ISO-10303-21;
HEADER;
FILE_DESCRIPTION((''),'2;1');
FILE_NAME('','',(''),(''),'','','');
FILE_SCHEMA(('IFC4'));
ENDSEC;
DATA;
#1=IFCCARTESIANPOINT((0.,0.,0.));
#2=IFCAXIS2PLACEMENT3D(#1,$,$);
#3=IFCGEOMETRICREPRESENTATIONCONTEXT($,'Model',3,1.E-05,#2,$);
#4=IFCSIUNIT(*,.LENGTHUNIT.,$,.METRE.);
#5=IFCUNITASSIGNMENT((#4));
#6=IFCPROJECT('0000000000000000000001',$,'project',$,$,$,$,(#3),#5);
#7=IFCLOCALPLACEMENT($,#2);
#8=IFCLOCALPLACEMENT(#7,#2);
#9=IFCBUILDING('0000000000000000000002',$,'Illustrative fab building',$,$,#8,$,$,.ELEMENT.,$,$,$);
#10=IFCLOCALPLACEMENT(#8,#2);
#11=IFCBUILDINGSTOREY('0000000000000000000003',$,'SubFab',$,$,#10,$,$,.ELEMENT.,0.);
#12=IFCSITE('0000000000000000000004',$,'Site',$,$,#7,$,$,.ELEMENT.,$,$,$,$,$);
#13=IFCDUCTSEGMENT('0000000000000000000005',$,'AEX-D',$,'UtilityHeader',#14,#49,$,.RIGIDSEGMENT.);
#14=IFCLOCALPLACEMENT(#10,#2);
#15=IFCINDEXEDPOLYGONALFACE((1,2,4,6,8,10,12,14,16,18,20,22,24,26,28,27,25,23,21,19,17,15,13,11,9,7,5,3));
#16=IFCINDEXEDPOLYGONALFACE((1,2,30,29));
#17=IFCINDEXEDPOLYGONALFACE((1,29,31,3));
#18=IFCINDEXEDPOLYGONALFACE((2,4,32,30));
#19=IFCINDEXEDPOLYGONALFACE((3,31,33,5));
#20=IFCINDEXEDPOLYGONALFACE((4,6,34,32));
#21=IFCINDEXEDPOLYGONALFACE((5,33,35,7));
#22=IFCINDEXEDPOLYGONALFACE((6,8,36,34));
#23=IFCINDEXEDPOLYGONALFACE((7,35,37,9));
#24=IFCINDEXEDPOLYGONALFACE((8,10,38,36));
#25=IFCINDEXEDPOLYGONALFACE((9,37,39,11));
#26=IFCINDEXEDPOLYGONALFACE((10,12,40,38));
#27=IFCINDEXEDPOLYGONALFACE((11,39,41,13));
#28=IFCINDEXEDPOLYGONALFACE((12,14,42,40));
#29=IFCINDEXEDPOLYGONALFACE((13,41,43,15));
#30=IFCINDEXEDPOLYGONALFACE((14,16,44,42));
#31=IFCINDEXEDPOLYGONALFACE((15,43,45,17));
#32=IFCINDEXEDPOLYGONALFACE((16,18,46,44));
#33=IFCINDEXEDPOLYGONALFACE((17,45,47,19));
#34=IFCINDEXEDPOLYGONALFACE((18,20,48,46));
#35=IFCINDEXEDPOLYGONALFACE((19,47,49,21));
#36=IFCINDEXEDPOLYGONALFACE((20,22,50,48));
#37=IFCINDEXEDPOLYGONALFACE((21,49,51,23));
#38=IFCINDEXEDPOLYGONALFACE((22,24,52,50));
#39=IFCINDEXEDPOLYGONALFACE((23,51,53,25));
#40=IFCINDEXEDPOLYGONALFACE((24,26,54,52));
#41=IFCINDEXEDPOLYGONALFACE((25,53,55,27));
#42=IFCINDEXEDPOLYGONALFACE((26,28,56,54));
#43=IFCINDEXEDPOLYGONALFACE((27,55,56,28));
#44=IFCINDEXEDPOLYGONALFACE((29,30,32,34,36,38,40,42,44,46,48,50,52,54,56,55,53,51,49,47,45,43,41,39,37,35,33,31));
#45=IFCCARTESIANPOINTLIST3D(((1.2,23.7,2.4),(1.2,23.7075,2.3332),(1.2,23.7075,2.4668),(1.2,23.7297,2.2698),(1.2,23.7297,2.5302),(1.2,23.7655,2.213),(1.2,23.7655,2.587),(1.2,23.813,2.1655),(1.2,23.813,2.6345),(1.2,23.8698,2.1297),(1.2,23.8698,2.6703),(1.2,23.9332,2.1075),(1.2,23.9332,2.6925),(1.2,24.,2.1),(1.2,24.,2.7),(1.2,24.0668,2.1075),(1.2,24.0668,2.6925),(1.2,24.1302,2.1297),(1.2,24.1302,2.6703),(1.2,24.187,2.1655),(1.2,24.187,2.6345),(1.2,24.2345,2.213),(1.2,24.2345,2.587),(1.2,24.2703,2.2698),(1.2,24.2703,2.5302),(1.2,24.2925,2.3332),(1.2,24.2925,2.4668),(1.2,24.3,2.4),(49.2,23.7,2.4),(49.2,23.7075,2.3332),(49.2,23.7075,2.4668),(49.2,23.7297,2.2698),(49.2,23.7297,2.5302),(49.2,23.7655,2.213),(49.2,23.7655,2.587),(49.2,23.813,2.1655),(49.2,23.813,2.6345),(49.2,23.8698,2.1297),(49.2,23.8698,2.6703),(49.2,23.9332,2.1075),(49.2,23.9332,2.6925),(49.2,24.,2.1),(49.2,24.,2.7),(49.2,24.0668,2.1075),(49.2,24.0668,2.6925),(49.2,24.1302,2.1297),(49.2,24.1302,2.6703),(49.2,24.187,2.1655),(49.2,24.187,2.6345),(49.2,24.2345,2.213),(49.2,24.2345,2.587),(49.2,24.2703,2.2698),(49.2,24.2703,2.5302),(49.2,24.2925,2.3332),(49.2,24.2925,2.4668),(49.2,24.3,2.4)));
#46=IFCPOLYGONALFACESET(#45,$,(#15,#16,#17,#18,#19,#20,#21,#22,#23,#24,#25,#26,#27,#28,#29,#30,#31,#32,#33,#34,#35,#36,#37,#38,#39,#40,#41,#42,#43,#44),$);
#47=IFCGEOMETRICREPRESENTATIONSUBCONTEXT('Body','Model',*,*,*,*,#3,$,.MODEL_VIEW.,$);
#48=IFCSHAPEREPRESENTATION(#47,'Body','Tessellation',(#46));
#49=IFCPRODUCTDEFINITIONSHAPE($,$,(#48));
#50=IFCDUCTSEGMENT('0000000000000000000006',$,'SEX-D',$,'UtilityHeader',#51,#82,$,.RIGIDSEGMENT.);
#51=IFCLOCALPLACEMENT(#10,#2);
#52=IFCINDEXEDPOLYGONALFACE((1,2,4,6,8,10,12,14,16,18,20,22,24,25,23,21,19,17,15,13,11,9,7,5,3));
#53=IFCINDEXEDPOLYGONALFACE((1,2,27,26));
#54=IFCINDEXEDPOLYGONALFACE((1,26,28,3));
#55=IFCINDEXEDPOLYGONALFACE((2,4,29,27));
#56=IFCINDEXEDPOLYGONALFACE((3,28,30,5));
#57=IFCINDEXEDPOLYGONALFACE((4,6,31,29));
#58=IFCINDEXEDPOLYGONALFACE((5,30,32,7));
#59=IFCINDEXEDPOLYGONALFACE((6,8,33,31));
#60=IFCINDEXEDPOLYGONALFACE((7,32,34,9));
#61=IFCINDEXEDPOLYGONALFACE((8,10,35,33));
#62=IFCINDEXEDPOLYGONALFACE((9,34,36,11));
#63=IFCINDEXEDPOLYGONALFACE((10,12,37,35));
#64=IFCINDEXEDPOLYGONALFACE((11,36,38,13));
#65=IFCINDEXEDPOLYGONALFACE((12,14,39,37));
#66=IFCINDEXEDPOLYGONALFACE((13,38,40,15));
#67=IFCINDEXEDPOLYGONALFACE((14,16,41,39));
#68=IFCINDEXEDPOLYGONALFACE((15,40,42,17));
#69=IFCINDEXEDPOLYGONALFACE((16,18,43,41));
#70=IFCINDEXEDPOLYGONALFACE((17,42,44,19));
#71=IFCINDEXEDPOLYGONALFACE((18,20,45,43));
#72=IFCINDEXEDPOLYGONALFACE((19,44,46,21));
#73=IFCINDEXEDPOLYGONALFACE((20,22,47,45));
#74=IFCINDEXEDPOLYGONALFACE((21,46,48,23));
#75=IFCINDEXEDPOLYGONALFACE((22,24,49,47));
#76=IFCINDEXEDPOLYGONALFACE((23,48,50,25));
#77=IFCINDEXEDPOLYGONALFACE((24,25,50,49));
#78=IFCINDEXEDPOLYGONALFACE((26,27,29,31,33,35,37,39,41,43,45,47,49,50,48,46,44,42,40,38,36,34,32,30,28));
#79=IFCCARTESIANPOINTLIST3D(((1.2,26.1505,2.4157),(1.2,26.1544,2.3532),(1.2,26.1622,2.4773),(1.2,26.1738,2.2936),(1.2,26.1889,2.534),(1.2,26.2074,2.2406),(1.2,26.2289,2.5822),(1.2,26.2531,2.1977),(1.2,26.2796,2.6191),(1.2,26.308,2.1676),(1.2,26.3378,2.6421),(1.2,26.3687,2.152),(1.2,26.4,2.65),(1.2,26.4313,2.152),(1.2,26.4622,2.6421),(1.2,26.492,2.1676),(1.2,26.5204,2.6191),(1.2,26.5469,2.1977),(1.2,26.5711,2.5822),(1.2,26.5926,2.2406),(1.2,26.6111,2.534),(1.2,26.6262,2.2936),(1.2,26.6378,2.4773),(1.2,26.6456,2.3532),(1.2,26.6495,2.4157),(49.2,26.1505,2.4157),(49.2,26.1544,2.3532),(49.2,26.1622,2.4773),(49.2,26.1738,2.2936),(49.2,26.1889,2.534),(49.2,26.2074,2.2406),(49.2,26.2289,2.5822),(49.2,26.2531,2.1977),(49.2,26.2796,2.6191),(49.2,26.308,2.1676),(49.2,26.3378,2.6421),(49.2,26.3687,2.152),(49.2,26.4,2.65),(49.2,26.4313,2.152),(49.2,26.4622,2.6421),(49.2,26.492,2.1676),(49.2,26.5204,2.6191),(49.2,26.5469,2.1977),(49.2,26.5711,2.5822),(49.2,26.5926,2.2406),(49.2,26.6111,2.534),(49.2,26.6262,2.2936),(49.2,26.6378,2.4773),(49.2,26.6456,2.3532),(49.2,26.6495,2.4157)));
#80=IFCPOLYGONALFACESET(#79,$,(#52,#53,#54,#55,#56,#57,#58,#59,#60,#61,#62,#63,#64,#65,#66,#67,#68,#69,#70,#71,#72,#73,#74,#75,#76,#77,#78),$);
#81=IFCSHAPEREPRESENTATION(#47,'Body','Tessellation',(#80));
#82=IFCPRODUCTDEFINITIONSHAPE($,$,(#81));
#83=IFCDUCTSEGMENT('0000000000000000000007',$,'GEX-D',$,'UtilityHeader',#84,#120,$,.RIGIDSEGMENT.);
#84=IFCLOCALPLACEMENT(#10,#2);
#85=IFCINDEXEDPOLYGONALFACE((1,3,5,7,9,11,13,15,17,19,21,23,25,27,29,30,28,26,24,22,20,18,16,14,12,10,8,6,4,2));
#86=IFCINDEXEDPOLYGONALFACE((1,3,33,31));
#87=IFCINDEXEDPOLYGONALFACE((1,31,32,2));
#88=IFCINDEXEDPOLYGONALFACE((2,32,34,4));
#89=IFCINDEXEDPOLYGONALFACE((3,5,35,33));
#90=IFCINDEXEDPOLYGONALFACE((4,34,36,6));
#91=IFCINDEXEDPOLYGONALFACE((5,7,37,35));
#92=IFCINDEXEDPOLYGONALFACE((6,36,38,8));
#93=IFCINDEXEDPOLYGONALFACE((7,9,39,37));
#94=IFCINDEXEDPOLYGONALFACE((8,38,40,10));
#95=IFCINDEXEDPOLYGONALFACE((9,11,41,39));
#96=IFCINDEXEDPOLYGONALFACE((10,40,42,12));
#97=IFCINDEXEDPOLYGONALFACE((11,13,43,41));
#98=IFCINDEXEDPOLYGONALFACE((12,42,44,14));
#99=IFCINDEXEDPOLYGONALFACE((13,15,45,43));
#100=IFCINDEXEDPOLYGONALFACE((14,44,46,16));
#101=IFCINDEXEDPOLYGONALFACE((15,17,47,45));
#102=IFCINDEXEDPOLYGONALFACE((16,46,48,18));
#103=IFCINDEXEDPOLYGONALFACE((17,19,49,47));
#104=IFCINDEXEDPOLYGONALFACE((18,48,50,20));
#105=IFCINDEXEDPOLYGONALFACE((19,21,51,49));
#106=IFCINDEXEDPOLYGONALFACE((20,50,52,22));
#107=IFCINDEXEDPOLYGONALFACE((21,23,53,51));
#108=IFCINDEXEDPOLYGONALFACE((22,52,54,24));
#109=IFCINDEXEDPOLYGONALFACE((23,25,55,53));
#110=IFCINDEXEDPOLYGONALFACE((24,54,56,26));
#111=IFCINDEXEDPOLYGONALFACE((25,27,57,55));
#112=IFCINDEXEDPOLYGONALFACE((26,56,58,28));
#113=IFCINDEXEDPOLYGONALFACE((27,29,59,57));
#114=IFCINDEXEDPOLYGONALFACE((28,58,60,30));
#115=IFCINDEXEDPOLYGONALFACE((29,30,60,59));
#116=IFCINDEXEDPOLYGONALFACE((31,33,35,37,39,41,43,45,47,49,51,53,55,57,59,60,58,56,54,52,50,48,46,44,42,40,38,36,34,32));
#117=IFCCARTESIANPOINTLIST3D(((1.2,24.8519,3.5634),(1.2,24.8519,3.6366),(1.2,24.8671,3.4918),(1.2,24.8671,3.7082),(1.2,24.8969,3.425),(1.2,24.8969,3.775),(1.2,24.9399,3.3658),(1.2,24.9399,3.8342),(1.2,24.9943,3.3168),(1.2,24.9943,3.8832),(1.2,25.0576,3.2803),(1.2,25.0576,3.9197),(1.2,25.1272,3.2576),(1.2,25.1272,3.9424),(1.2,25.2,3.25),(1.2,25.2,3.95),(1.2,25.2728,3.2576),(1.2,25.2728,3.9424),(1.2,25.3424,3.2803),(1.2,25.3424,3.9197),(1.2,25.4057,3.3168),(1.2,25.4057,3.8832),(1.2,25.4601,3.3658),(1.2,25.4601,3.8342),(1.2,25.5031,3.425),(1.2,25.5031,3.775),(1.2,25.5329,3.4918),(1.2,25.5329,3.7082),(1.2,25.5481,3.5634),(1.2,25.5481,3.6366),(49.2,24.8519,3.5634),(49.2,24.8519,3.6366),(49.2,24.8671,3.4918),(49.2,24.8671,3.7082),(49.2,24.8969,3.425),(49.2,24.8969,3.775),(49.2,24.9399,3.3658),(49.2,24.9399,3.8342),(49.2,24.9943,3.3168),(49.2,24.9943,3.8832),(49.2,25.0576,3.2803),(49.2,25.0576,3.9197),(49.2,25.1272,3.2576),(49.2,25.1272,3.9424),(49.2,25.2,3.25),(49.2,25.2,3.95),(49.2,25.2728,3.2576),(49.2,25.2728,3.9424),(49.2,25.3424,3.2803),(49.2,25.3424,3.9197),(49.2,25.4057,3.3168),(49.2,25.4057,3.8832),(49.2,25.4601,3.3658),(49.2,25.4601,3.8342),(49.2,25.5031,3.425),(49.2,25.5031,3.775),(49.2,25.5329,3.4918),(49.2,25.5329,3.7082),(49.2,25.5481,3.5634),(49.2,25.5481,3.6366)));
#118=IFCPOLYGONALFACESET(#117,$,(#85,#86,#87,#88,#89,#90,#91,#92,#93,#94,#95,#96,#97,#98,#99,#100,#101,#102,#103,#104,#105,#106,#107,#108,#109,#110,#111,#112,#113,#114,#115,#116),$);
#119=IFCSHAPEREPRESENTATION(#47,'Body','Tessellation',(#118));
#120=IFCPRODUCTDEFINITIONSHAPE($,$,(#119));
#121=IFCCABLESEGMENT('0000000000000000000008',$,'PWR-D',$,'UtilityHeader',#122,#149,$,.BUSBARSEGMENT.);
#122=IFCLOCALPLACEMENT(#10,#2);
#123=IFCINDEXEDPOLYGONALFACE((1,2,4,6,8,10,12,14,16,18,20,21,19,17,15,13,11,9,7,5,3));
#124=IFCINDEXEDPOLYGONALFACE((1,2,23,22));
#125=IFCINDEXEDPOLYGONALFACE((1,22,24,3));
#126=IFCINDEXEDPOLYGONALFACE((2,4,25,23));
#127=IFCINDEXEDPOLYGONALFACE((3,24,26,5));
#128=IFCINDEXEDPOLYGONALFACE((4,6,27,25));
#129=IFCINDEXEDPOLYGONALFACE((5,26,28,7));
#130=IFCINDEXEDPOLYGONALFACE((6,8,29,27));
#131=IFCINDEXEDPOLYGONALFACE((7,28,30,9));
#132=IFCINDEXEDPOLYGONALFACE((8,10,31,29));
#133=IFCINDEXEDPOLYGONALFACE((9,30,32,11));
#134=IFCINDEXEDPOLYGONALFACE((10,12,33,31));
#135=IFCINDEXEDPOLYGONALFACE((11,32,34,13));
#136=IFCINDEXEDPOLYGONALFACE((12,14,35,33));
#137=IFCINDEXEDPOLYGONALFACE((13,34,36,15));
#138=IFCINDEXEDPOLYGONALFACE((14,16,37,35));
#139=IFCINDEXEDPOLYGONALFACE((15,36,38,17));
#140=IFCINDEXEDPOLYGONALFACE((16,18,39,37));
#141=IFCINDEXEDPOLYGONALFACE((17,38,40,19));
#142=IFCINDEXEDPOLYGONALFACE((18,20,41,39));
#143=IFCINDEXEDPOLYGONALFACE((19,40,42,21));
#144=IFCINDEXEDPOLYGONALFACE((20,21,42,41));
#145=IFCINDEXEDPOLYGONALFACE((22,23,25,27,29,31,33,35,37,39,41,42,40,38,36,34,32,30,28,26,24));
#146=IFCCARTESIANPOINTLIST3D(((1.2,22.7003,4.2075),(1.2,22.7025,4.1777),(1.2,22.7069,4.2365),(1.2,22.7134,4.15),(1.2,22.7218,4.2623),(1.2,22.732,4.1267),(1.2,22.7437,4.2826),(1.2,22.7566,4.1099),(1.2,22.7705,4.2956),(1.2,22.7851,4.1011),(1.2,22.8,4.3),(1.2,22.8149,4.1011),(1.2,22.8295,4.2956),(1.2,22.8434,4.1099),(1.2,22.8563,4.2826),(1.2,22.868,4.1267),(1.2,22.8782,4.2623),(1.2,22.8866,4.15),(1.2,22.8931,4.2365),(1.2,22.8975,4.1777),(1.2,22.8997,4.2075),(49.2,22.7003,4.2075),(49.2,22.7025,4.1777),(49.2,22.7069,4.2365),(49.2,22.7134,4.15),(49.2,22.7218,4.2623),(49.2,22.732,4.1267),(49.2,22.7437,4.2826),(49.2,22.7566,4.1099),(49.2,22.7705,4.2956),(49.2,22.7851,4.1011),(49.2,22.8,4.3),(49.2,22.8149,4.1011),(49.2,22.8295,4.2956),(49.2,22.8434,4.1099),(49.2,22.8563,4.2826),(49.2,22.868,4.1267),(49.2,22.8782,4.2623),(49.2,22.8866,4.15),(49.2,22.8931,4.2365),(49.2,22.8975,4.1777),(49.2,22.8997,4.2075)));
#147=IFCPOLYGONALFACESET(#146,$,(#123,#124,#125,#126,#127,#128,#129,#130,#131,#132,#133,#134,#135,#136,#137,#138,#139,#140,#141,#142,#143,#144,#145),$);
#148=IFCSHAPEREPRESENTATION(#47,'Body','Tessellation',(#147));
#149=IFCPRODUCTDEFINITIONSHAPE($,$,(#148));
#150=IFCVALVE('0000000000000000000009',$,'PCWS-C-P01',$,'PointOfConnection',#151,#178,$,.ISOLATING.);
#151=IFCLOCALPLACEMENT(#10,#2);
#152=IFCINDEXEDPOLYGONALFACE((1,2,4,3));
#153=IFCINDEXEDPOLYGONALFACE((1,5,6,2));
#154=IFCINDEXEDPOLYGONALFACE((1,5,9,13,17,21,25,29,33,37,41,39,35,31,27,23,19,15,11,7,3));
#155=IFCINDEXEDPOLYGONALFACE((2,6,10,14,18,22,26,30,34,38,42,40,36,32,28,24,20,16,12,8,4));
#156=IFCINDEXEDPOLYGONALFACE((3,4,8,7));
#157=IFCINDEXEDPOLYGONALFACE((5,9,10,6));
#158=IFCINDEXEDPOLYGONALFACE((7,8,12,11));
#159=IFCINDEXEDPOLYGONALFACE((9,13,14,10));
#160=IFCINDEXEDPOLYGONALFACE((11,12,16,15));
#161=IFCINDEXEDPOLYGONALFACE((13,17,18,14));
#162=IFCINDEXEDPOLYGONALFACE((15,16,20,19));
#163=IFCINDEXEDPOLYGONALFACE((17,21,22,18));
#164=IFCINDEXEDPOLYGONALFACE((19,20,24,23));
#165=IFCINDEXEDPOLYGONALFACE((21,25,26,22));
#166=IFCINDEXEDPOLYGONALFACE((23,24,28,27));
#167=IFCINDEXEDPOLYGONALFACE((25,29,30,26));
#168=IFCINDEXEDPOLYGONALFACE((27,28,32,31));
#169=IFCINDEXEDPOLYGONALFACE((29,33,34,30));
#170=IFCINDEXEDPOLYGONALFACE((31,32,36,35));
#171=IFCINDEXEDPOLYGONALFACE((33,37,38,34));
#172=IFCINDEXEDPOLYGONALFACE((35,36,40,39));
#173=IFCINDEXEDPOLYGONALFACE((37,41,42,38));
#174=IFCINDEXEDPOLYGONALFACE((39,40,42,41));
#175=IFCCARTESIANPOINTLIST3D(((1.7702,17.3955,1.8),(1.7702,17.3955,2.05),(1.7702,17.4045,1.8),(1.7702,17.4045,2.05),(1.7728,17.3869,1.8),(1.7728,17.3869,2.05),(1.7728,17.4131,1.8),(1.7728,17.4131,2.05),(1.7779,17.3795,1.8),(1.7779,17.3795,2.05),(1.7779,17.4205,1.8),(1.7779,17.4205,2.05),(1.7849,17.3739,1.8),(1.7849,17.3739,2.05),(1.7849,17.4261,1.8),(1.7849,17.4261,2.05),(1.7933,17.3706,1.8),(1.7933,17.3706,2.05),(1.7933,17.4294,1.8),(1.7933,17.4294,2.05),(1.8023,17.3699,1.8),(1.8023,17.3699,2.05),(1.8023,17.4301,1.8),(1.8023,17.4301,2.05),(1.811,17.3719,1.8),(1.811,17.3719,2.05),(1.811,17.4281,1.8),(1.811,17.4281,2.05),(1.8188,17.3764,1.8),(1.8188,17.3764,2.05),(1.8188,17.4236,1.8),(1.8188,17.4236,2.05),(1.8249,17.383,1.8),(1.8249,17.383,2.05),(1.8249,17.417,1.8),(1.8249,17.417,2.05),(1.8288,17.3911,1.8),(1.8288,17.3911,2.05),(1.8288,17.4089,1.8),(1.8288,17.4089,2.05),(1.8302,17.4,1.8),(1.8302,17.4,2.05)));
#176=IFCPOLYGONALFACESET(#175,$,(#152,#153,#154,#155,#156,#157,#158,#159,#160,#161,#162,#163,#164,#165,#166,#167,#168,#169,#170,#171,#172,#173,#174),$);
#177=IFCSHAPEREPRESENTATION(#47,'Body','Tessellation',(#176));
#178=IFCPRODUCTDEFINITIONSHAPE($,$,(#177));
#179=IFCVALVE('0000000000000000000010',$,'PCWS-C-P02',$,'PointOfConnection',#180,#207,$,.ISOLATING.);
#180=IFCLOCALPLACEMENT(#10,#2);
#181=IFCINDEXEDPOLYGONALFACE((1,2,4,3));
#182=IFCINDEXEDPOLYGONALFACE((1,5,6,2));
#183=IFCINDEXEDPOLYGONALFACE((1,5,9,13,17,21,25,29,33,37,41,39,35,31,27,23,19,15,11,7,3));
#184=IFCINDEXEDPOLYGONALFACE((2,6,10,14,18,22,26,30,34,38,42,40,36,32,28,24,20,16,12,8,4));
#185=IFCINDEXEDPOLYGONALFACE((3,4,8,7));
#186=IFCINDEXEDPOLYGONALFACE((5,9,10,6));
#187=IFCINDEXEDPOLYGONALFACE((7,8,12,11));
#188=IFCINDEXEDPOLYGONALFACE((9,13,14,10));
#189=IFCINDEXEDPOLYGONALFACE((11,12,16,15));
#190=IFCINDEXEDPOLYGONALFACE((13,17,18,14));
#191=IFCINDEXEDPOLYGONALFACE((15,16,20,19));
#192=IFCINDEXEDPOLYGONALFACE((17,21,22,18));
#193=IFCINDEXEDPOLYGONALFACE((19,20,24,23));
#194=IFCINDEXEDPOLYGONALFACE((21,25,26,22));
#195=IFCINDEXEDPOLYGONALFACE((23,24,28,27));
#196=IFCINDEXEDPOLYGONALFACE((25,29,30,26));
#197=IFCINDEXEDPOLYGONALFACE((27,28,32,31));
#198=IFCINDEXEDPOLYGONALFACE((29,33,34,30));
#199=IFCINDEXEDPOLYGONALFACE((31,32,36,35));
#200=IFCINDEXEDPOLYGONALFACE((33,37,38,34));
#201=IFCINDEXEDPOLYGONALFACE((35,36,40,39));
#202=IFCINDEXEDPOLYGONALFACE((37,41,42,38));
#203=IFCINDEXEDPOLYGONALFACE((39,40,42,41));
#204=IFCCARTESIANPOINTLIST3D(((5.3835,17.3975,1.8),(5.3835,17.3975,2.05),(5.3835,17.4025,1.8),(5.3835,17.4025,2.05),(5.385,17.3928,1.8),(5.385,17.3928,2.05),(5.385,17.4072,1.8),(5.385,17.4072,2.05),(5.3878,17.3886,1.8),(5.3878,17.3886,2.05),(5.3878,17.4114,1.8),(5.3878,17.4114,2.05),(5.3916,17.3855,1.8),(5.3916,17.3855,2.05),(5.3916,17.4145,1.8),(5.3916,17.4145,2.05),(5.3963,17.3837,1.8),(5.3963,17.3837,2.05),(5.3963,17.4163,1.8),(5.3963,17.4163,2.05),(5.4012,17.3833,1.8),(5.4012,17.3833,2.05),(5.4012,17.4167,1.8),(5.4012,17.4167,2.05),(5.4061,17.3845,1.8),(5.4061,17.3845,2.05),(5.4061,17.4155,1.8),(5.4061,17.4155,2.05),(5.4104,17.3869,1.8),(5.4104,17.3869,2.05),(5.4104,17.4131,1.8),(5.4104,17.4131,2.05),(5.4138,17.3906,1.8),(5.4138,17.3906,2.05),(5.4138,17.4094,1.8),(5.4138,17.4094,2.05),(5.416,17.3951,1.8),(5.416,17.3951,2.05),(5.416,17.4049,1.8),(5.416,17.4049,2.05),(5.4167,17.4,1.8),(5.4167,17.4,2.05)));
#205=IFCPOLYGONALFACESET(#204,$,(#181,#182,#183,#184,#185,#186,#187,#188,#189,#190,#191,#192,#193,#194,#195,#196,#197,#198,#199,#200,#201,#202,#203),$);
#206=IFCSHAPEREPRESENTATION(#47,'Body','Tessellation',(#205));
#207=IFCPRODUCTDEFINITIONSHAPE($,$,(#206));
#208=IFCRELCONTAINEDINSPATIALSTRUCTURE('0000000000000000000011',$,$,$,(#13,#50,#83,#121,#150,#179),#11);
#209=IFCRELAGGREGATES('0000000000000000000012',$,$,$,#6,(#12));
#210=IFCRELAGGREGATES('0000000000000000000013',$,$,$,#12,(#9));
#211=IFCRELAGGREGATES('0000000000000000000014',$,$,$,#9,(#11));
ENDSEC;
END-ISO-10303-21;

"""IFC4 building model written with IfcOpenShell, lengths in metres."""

from ifc_helpers import new_model, entity, si_unit, frame, origin, place, context, subcontext, project, spatial, element, save


model = new_model("IFC4")

# Units and contexts
model_context = context("Model", 3, precision=1e-05, world=origin())
body_context = subcontext(model_context, "Body", "Model", "MODEL_VIEW")
ifc_project = project(units=[si_unit("LENGTHUNIT", "METRE")], contexts=[model_context])

# Site, building, storey
site_placement = place(None, origin())
site = spatial("IfcSite", under=ifc_project, at=site_placement, Name="Site", CompositionType="ELEMENT")
building_placement = place(site_placement, origin())
building = spatial("IfcBuilding", under=site, at=building_placement, Name="Illustrative fab building", CompositionType="ELEMENT")
storey_placement = place(building_placement, origin())
storey = spatial("IfcBuildingStorey", under=building, at=storey_placement, Name="SubFab", CompositionType="ELEMENT", Elevation=0.0)

# Duct segments
duct_segment_1_placement = place(storey_placement, frame((1.2, 24.0, 2.4)))
element("IfcDuctSegment", 1, at=duct_segment_1_placement, inside=storey, Name="AEX-D", ObjectType="UtilityHeader", PredefinedType="RIGIDSEGMENT", context=body_context, shape_type="AdvancedSweptSolid", body=[
    entity("IfcSweptDiskSolid", entity("IfcPolyline", [entity("IfcCartesianPoint", [0.0, 0.0, 0.0]), entity("IfcCartesianPoint", [48.0, 0.0, 0.0])]), 0.3),
])
duct_segment_2_placement = place(storey_placement, frame((1.2, 26.4, 2.4)))
element("IfcDuctSegment", 2, at=duct_segment_2_placement, inside=storey, Name="SEX-D", ObjectType="UtilityHeader", PredefinedType="RIGIDSEGMENT", context=body_context, shape_type="AdvancedSweptSolid", body=[
    entity("IfcSweptDiskSolid", entity("IfcPolyline", [entity("IfcCartesianPoint", [0.0, 0.0, 0.0]), entity("IfcCartesianPoint", [48.0, 0.0, 0.0])]), 0.25),
])
duct_segment_3_placement = place(storey_placement, frame((1.2, 25.2, 3.6)))
element("IfcDuctSegment", 3, at=duct_segment_3_placement, inside=storey, Name="GEX-D", ObjectType="UtilityHeader", PredefinedType="RIGIDSEGMENT", context=body_context, shape_type="AdvancedSweptSolid", body=[
    entity("IfcSweptDiskSolid", entity("IfcPolyline", [entity("IfcCartesianPoint", [0.0, 0.0, 0.0]), entity("IfcCartesianPoint", [48.0, 0.0, 0.0])]), 0.35),
])

# Cable segment
cable_segment_placement = place(storey_placement, frame((1.2, 22.8, 4.2)))
element("IfcCableSegment", 4, at=cable_segment_placement, inside=storey, Name="PWR-D", ObjectType="UtilityHeader", PredefinedType="BUSBARSEGMENT", context=body_context, shape_type="AdvancedSweptSolid", body=[
    entity("IfcSweptDiskSolid", entity("IfcPolyline", [entity("IfcCartesianPoint", [0.0, 0.0, 0.0]), entity("IfcCartesianPoint", [48.0, 0.0, 0.0])]), 0.1),
])

# Valves
valve_1_placement = place(storey_placement, frame((1.8, 17.4, 1.8)))
element("IfcValve", 5, at=valve_1_placement, inside=storey, Name="PCWS-C-P01", ObjectType="PointOfConnection", PredefinedType="ISOLATING", context=body_context, shape_type="AdvancedSweptSolid", body=[
    entity("IfcSweptDiskSolid", entity("IfcPolyline", [entity("IfcCartesianPoint", [0.0, 0.0, 0.0]), entity("IfcCartesianPoint", [0.0, 0.0, 0.25])]), 0.0302),
])
valve_2_placement = place(storey_placement, frame((5.4, 17.4, 1.8)))
element("IfcValve", 6, at=valve_2_placement, inside=storey, Name="PCWS-C-P02", ObjectType="PointOfConnection", PredefinedType="ISOLATING", context=body_context, shape_type="AdvancedSweptSolid", body=[
    entity("IfcSweptDiskSolid", entity("IfcPolyline", [entity("IfcCartesianPoint", [0.0, 0.0, 0.0]), entity("IfcCartesianPoint", [0.0, 0.0, 0.25])]), 0.0167),
])

save(model, "model.ifc")
